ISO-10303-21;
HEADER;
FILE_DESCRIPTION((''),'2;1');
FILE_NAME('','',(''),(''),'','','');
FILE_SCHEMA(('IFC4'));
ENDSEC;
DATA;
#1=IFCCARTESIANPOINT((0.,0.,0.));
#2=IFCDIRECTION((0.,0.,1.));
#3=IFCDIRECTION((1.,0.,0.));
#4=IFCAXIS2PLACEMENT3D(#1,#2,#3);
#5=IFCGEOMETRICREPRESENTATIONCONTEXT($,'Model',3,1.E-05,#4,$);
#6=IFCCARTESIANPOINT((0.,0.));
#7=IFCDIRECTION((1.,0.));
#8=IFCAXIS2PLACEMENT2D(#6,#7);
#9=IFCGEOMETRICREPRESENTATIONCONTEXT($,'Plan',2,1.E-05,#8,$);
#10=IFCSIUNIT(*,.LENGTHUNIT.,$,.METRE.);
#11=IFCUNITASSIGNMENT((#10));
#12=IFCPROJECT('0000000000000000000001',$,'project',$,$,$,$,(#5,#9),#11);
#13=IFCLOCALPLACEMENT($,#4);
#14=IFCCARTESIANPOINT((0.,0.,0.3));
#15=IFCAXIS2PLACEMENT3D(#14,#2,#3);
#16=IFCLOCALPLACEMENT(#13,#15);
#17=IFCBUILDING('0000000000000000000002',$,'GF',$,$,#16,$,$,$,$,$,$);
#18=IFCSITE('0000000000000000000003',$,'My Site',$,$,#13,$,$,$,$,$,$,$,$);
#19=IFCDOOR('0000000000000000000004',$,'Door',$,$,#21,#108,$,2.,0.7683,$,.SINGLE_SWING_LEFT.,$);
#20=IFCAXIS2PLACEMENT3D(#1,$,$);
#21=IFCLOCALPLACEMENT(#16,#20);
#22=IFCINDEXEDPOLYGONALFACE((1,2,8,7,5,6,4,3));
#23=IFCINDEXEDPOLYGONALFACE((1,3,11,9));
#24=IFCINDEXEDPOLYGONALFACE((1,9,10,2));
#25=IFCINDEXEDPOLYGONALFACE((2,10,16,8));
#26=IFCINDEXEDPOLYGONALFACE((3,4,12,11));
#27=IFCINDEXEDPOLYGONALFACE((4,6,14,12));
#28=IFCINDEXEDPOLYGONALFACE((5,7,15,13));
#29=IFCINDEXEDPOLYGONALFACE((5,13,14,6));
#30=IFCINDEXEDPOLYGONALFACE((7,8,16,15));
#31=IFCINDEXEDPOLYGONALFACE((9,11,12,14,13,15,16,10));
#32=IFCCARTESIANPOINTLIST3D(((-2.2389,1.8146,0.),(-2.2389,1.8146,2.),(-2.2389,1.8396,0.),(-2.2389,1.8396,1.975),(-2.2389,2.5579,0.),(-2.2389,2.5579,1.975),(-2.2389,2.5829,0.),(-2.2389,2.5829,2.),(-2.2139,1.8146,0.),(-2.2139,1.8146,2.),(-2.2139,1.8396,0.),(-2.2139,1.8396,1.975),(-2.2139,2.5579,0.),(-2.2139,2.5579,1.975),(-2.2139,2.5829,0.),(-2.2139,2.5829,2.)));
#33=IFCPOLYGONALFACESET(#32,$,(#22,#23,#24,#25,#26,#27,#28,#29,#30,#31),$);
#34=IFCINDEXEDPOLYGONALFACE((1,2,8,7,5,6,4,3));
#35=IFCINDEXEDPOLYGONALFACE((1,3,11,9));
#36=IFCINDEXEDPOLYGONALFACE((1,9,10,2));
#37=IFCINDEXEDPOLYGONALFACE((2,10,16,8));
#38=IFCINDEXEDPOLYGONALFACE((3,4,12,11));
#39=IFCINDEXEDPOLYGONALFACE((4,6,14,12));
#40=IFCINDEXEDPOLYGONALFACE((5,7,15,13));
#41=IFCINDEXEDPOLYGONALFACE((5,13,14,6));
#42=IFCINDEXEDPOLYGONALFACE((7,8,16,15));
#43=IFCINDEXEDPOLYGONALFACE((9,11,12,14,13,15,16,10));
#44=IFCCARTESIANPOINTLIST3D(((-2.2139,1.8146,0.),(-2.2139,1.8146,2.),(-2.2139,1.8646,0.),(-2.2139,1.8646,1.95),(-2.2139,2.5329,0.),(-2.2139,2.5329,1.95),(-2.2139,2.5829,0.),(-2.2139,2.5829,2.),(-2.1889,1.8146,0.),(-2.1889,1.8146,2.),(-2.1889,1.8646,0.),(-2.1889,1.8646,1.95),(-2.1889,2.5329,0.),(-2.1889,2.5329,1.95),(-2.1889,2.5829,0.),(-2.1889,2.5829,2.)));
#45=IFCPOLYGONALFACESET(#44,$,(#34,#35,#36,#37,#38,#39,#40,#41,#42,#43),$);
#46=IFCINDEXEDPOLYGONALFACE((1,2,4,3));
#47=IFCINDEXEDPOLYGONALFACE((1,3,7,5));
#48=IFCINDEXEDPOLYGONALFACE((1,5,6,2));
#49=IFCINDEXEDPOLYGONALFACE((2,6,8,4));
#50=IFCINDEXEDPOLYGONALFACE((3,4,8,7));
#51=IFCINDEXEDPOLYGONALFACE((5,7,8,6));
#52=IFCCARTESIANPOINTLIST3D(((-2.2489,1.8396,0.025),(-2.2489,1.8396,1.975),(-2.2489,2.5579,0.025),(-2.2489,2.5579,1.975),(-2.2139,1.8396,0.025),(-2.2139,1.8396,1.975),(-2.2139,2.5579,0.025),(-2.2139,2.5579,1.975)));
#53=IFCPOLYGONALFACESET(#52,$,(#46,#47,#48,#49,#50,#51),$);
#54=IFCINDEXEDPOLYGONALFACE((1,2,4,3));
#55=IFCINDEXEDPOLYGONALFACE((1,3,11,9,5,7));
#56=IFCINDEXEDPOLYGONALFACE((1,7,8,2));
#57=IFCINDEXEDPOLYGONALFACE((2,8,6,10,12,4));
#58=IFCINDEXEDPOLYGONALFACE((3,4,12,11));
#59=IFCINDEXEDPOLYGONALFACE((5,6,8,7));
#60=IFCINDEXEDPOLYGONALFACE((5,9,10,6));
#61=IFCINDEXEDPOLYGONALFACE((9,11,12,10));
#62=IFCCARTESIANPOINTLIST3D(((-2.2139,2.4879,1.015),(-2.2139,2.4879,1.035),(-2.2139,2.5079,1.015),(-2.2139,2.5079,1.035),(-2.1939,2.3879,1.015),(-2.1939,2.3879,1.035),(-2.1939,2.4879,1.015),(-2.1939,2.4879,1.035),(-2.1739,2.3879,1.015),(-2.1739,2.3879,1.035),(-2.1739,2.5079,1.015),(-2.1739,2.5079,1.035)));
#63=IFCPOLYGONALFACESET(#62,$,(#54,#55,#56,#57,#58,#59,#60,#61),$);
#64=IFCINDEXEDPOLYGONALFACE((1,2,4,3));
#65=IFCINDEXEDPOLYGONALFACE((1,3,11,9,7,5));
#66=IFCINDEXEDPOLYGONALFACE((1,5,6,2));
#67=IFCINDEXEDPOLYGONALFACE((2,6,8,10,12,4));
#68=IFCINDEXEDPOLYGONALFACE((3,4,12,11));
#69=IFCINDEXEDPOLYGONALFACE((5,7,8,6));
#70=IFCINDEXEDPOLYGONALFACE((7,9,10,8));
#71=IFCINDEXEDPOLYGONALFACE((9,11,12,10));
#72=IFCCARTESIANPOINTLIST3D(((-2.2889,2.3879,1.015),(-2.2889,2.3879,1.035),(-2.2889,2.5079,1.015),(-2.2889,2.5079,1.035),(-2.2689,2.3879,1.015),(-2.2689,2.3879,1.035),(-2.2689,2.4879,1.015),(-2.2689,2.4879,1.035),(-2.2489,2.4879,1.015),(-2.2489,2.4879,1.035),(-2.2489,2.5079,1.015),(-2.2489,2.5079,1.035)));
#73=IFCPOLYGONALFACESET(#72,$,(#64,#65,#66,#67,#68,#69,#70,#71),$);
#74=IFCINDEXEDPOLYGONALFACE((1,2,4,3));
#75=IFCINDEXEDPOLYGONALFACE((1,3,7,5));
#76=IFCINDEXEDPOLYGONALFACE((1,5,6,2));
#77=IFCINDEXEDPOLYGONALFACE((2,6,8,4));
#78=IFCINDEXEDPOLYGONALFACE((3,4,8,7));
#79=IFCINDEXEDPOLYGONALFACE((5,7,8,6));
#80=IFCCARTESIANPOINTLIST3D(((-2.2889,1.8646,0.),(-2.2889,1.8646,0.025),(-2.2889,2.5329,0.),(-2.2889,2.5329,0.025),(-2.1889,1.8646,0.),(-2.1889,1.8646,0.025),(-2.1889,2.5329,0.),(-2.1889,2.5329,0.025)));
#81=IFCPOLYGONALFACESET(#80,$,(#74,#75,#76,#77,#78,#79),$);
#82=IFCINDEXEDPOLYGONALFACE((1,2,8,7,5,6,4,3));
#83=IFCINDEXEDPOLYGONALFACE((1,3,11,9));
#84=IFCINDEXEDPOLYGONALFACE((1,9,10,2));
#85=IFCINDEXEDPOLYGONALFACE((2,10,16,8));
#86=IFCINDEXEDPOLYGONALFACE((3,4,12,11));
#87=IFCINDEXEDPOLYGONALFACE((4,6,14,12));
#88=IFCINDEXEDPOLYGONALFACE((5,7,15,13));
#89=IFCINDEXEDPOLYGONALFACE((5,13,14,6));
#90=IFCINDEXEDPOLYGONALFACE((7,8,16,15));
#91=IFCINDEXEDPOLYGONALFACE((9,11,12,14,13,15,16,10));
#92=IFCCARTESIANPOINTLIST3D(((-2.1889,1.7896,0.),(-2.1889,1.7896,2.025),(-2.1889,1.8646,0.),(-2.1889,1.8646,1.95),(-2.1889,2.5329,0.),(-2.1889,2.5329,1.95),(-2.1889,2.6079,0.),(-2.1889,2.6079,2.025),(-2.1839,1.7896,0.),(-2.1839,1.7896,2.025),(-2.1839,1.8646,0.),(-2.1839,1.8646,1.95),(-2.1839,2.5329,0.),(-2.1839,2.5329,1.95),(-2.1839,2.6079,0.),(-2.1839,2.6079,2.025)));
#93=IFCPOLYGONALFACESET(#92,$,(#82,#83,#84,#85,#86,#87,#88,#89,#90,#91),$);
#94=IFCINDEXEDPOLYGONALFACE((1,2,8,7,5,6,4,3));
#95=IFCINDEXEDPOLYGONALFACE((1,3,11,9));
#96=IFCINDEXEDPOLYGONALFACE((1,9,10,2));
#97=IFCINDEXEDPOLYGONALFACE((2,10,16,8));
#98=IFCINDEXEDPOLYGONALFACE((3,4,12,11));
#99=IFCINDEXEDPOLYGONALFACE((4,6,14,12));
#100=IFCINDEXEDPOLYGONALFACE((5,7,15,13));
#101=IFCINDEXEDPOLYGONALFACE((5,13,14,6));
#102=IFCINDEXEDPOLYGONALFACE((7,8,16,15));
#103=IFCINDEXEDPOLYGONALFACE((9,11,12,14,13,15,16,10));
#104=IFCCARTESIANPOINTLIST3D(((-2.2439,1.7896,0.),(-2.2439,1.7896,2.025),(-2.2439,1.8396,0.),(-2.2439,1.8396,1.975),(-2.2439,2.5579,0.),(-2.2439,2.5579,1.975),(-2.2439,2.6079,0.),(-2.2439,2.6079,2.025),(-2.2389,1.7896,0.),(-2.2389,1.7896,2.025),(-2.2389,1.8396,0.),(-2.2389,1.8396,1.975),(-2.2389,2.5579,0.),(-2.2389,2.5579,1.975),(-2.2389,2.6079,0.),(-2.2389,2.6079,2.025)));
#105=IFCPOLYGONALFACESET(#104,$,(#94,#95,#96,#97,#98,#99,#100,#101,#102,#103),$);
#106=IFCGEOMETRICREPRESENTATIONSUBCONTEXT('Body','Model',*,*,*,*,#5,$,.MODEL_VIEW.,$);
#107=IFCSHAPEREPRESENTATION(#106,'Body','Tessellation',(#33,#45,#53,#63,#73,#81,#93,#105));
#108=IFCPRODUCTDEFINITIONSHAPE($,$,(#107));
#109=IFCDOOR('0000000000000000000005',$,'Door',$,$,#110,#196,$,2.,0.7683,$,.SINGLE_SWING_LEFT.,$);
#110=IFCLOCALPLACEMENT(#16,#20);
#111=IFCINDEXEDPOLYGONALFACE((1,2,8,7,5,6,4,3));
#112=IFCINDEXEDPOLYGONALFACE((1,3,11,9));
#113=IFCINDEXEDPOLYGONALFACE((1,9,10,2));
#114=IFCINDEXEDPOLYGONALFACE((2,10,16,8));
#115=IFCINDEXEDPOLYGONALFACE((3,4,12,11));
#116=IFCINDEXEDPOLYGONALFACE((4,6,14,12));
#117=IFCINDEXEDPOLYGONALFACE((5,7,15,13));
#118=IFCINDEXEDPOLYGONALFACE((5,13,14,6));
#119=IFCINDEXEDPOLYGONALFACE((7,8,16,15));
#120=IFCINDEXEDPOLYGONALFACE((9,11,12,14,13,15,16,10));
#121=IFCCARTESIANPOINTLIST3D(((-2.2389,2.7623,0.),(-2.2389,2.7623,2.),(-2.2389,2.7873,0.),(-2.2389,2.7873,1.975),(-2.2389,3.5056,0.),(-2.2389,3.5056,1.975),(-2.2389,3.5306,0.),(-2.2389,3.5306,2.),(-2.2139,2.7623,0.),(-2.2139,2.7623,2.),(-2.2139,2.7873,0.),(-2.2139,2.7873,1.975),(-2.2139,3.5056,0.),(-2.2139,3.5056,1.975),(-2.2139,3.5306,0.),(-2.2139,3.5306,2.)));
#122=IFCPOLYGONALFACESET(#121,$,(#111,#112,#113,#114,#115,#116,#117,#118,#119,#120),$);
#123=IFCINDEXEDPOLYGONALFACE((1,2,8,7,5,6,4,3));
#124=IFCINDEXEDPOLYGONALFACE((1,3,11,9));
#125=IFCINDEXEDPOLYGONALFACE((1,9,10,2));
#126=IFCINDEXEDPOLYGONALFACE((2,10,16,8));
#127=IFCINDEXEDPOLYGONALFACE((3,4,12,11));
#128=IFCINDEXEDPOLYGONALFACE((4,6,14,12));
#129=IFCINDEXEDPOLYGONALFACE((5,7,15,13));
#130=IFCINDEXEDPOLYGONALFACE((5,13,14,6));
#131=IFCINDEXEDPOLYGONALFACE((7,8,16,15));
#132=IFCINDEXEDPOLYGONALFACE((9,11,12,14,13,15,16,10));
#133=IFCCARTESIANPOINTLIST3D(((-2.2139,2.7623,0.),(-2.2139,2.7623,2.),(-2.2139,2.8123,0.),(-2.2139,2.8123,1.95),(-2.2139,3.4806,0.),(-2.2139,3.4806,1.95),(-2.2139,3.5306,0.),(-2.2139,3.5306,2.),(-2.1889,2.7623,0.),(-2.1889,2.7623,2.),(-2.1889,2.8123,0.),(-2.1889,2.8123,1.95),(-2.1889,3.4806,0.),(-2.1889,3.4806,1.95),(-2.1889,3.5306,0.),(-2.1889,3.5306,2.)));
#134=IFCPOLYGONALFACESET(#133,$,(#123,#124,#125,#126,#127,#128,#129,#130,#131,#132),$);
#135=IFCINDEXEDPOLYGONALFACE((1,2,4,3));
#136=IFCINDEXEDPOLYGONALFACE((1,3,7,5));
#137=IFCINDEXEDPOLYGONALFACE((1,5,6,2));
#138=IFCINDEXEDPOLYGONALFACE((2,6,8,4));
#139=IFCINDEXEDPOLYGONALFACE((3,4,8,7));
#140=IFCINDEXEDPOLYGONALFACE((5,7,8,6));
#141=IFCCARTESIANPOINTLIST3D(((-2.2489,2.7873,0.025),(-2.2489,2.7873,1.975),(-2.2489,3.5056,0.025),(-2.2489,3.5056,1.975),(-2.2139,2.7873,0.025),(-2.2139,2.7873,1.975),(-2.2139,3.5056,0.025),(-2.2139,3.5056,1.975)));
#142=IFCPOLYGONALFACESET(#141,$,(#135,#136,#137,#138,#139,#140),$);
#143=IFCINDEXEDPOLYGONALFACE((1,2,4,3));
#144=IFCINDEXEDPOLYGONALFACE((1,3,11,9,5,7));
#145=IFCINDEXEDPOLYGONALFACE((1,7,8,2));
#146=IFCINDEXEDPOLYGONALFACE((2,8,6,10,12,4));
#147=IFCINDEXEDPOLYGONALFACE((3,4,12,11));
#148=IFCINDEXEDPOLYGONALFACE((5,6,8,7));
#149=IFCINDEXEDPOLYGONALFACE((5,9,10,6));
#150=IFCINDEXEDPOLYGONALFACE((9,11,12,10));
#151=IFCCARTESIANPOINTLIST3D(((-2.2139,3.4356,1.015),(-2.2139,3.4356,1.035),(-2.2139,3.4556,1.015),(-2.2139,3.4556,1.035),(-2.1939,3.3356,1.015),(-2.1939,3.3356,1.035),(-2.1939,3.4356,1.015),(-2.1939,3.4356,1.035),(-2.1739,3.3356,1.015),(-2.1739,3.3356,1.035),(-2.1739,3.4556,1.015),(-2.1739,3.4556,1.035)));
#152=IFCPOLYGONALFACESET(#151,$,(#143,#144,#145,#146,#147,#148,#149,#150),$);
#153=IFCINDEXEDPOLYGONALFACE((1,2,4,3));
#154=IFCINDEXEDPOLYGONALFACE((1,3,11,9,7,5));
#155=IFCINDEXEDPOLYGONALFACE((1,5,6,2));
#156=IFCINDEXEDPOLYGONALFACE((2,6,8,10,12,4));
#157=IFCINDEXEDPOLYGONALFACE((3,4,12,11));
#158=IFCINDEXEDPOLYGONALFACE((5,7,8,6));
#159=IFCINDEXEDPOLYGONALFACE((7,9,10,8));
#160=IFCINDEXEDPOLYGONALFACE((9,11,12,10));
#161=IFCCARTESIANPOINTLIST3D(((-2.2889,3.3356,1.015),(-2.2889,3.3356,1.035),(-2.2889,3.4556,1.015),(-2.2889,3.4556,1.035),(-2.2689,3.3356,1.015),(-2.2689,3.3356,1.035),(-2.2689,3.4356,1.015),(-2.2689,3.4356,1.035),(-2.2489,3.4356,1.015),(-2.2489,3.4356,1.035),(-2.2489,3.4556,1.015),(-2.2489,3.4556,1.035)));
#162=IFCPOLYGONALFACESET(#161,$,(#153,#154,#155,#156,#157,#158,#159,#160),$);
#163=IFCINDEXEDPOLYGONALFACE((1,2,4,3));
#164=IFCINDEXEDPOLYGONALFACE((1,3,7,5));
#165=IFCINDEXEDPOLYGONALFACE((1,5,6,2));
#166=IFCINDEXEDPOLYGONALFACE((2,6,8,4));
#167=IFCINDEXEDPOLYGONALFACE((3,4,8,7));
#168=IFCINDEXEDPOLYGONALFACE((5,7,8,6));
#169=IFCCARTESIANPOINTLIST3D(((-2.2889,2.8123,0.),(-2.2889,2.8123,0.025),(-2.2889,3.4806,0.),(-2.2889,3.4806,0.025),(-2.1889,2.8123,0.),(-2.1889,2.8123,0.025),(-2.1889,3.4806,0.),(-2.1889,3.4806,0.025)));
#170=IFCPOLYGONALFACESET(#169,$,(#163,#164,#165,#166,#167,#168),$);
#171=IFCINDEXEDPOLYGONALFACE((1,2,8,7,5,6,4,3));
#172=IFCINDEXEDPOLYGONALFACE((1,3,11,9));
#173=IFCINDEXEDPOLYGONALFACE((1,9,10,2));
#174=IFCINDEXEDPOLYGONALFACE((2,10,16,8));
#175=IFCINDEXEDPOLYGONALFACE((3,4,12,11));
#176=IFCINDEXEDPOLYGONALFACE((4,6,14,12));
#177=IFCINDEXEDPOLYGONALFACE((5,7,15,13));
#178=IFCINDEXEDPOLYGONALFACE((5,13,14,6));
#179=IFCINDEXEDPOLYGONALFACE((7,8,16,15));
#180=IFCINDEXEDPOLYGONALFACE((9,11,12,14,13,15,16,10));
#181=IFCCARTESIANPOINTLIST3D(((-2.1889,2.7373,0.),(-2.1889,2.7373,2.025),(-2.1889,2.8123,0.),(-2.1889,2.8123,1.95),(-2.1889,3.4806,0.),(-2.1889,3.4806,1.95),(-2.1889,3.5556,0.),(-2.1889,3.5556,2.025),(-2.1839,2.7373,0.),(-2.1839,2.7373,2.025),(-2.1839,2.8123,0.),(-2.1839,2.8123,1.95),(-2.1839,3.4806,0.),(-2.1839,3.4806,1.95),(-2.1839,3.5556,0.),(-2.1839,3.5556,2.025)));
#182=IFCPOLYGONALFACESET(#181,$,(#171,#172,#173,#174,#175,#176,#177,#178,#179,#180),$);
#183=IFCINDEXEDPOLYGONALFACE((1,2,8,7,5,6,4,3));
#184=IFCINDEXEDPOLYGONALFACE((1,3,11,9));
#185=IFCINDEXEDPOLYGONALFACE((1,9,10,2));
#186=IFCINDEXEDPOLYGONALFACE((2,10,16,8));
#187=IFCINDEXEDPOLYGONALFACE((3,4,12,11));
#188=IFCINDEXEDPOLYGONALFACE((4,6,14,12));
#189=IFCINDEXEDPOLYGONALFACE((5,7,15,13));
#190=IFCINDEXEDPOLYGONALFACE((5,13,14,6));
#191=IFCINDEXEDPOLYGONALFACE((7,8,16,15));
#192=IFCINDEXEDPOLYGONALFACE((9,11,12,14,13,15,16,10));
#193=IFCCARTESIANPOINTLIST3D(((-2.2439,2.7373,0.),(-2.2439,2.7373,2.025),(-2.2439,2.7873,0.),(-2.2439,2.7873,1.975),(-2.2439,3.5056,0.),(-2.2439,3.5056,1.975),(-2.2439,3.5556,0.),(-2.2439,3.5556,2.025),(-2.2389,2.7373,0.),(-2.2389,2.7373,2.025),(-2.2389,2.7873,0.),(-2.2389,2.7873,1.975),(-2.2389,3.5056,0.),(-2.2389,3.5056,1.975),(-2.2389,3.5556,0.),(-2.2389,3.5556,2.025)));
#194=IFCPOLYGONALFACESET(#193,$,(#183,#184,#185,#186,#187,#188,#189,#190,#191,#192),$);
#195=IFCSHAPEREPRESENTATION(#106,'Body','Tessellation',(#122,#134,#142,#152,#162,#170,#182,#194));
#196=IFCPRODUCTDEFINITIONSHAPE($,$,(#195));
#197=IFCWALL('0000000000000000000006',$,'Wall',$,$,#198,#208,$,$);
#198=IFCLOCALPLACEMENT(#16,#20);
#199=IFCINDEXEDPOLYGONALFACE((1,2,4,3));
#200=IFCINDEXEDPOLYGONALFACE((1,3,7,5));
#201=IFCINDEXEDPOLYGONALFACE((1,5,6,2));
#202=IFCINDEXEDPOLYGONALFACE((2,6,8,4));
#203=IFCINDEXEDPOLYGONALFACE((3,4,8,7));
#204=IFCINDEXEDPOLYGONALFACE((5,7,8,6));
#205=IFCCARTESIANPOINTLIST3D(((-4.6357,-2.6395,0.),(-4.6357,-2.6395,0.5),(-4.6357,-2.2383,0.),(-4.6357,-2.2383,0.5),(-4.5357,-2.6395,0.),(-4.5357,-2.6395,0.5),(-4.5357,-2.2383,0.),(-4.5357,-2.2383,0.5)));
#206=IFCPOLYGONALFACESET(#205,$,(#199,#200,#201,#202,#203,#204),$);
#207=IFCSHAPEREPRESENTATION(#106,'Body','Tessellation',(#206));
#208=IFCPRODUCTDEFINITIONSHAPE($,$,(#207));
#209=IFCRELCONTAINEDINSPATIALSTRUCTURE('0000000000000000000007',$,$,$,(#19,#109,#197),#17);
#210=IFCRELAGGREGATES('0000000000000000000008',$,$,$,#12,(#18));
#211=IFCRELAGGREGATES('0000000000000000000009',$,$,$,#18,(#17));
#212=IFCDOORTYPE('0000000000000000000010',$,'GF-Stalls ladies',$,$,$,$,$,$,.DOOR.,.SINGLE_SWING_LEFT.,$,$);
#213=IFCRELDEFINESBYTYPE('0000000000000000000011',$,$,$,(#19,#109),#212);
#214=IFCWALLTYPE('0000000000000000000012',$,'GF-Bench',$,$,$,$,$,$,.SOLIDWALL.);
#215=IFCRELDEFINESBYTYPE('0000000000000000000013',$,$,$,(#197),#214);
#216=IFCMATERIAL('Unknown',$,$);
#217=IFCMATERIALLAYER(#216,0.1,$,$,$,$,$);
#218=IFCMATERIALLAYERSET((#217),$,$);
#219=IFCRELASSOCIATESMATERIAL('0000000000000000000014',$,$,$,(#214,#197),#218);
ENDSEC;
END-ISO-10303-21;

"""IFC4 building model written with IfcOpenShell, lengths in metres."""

from ifc_helpers import new_model, entity, si_unit, frame, origin_with_axes, origin_2d_with_axis, place, context, subcontext, project, spatial, line, indexed_curve, outline, extrude, shape, source, transform, mapped, material, layer, layer_set, layer_usage, type_object, type_shapes, element, save


model = new_model("IFC4")

# Units and contexts
model_context = context("Model", 3, precision=1e-05, world=origin_with_axes())
plan_context = context("Plan", 2, precision=1e-05, world=origin_2d_with_axis())
body_context_1 = subcontext(model_context, "Body", "Model", "MODEL_VIEW")
body_context_2 = subcontext(plan_context, "Body", "Plan", "PLAN_VIEW")
ifc_project = project(units=[si_unit("LENGTHUNIT", "METRE")], contexts=[model_context, plan_context])

# Site, building
site_placement = place(None, origin_with_axes())
site = spatial("IfcSite", under=ifc_project, at=site_placement, Name="My Site")
building_placement = place(site_placement, frame((0.0, 0.0, 0.3), z_axis=(0.0, 0.0, 1.0), x_axis=(1.0, 0.0, 0.0)))
building = spatial("IfcBuilding", under=site, at=building_placement, Name="GF")

# Shared definitions
ifc_material = material(Name="Unknown")

# Shared definitions
door_type_1 = type_object("IfcDoorType", Name="GF-Stalls ladies", OperationType="SINGLE_SWING_LEFT", PredefinedType="DOOR")
shared_shape_1 = source(origin_with_axes(), body_context_1, "Body", "SweptSolid", [
    extrude(outline(indexed_curve([(0.0, 0.0), (0.0, 2.0), (0.7683, 2.0), (0.7683, 0.0), (0.7433, 0.0), (0.7433, 1.975), (0.025, 1.975), (0.025, 0.0)], segments=[line(1, 2, 3, 4, 5, 6, 7, 8, 1)])), frame((0.0, 0.025, 0.0), z_axis=(0.0, -1.0, 0.0), x_axis=(1.0, 0.0, 0.0)), (0.0, 0.0, -1.0), 0.025),
    extrude(outline(indexed_curve([(0.0, 0.0), (0.0, 2.0), (0.7683, 2.0), (0.7683, 0.0), (0.7183, 0.0), (0.7183, 1.95), (0.05, 1.95), (0.05, 0.0)], segments=[line(1, 2, 3, 4, 5, 6, 7, 8, 1)])), frame((0.0, 0.0, 0.0), z_axis=(0.0, -1.0, 0.0), x_axis=(1.0, 0.0, 0.0)), (0.0, 0.0, -1.0), 0.025),
    extrude(outline(indexed_curve([(0.0, 0.0), (0.7183, 0.0), (0.7183, 0.035), (0.0, 0.035)], segments=[line(1, 2, 3, 4, 1)])), frame((0.025, 0.025, 0.025), z_axis=(0.0, 0.0, 1.0), x_axis=(1.0, 0.0, 0.0)), (0.0, 0.0, 1.0), 1.95),
    extrude(outline(indexed_curve([(0.0, 0.0), (0.0, -0.04), (-0.12, -0.04), (-0.12, -0.02), (-0.02, -0.02), (-0.02, 0.0)], segments=[line(1, 2, 3, 4, 5, 6, 1)])), frame((0.6933, 0.025, 1.015), z_axis=(0.0, 0.0, 1.0), x_axis=(1.0, 0.0, 0.0)), (0.0, 0.0, 1.0), 0.02),
    extrude(outline(indexed_curve([(0.0, 0.0), (0.0, 0.04), (-0.12, 0.04), (-0.12, 0.02), (-0.02, 0.02), (-0.02, 0.0)], segments=[line(1, 2, 3, 4, 5, 6, 1)])), frame((0.6933, 0.06, 1.015), z_axis=(0.0, 0.0, 1.0), x_axis=(1.0, 0.0, 0.0)), (0.0, 0.0, 1.0), 0.02),
    extrude(outline(indexed_curve([(0.0, 0.0), (0.6683, 0.0), (0.6683, 0.1), (0.0, 0.1)], segments=[line(1, 2, 3, 4, 1)])), frame((0.05, 0.0, 0.0), z_axis=(0.0, 0.0, 1.0), x_axis=(1.0, 0.0, 0.0)), (0.0, 0.0, 1.0), 0.025),
    extrude(outline(indexed_curve([(0.0, 0.0), (0.0, 2.025), (0.8183, 2.025), (0.8183, 0.0), (0.7433, 0.0), (0.7433, 1.95), (0.075, 1.95), (0.075, 0.0)], segments=[line(1, 2, 3, 4, 5, 6, 7, 8, 1)])), frame((-0.025, -0.005, 0.0), z_axis=(0.0, -1.0, 0.0), x_axis=(1.0, 0.0, 0.0)), (0.0, 0.0, -1.0), 0.005),
    extrude(outline(indexed_curve([(0.0, 0.0), (0.0, 2.025), (0.8183, 2.025), (0.8183, 0.0), (0.7683, 0.0), (0.7683, 1.975), (0.05, 1.975), (0.05, 0.0)], segments=[line(1, 2, 3, 4, 5, 6, 7, 8, 1)])), frame((-0.025, 0.05, 0.0), z_axis=(0.0, -1.0, 0.0), x_axis=(1.0, 0.0, 0.0)), (0.0, 0.0, -1.0), 0.005),
])
shared_shape_2 = source(origin_with_axes(), body_context_2, "Body", "Curve2D", [
    entity("IfcIndexedPolyCurve", entity("IfcCartesianPointList2D", [[0.0, 0.0], [0.0, 0.05], [0.025, 0.05], [0.025, 0.025], [0.05, 0.025], [0.05, 0.0]]), [entity("IfcLineIndex", [1, 2, 3, 4, 5, 6, 1])]),
    entity("IfcIndexedPolyCurve", entity("IfcCartesianPointList2D", [[0.7683, 0.0], [0.7683, 0.05], [0.7433, 0.05], [0.7433, 0.025], [0.7183, 0.025], [0.7183, 0.0]]), [entity("IfcLineIndex", [1, 2, 3, 4, 5, 6, 1])]),
    entity("IfcTrimmedCurve", entity("IfcEllipse", entity("IfcAxis2Placement2D", entity("IfcCartesianPoint", [0.06, 0.05]), entity("IfcDirection", [1.0, 0.0])), 0.6833, 0.7183), [entity("IfcCartesianPoint", [0.7433, 0.05])], [entity("IfcCartesianPoint", [0.06, 0.7683])], True, "CARTESIAN"),
    entity("IfcIndexedPolyCurve", entity("IfcCartesianPointList2D", [[0.025, 0.05], [0.06, 0.05], [0.06, 0.7683], [0.025, 0.7683]]), [entity("IfcLineIndex", [1, 2, 3, 4, 1])]),
])
type_shapes(door_type_1, [shared_shape_1, shared_shape_2])

# Doors
for number, where, z_axis, x_axis, name in (
    (1, (-2.1889, 1.8146, 0.0), (0.0, 0.0, 1.0), (0.0, 1.0, 0.0), "Door"),
    (2, (-2.1889, 2.7623, 0.0), (0.0, 0.0, 1.0), (0.0, 1.0, 0.0), "Door"),
):
    element("IfcDoor", number, at=place(building_placement, frame(where, z_axis=z_axis, x_axis=x_axis)), inside=building, type_object=door_type_1, Name=name, OperationType="SINGLE_SWING_LEFT", OverallHeight=2.0, OverallWidth=0.7683, shapes=[
        shape(body_context_1, "Body", "MappedRepresentation", [mapped(shared_shape_1, transform((0.0, 0.0, 0.0), x_axis=(1.0, 0.0, 0.0), y_axis=(0.0, 1.0, 0.0), z_axis=(0.0, 0.0, 1.0), scale=1.0))]),
        shape(body_context_2, "Body", "MappedRepresentation", [mapped(shared_shape_2, transform((0.0, 0.0, 0.0), x_axis=(1.0, 0.0, 0.0), y_axis=(0.0, 1.0, 0.0), z_axis=(0.0, 0.0, 1.0), scale=1.0))]),
    ])

# Wall
ifc_layer_1 = layer(ifc_material, 0.1)
ifc_layer_set_1 = layer_set([ifc_layer_1])
ifc_layer_usage_1 = layer_usage(ifc_layer_set_1, "AXIS2", "POSITIVE", 0.0)
wall_type_1 = type_object("IfcWallType", Name="GF-Bench", PredefinedType="SOLIDWALL", material=ifc_layer_set_1)
wall_1_placement = place(building_placement, frame((-4.6357, -2.2383, 0.0), z_axis=(0.0, 0.0, 1.0), x_axis=(-0.000002, -1.0, 0.0)))
element("IfcWall", 3, at=wall_1_placement, inside=building, type_object=wall_type_1, material=ifc_layer_usage_1, Name="Wall", context=body_context_1, shape_type="SweptSolid", body=[
    extrude(outline(indexed_curve([(0.0, 0.0), (0.0, 0.1), (0.4011, 0.1), (0.4011, 0.0)], segments=[line(1, 2, 3, 4, 1)])), origin_with_axes(), (0.0, 0.0, 1.0), 0.5),
])

save(model, "model.ifc")
